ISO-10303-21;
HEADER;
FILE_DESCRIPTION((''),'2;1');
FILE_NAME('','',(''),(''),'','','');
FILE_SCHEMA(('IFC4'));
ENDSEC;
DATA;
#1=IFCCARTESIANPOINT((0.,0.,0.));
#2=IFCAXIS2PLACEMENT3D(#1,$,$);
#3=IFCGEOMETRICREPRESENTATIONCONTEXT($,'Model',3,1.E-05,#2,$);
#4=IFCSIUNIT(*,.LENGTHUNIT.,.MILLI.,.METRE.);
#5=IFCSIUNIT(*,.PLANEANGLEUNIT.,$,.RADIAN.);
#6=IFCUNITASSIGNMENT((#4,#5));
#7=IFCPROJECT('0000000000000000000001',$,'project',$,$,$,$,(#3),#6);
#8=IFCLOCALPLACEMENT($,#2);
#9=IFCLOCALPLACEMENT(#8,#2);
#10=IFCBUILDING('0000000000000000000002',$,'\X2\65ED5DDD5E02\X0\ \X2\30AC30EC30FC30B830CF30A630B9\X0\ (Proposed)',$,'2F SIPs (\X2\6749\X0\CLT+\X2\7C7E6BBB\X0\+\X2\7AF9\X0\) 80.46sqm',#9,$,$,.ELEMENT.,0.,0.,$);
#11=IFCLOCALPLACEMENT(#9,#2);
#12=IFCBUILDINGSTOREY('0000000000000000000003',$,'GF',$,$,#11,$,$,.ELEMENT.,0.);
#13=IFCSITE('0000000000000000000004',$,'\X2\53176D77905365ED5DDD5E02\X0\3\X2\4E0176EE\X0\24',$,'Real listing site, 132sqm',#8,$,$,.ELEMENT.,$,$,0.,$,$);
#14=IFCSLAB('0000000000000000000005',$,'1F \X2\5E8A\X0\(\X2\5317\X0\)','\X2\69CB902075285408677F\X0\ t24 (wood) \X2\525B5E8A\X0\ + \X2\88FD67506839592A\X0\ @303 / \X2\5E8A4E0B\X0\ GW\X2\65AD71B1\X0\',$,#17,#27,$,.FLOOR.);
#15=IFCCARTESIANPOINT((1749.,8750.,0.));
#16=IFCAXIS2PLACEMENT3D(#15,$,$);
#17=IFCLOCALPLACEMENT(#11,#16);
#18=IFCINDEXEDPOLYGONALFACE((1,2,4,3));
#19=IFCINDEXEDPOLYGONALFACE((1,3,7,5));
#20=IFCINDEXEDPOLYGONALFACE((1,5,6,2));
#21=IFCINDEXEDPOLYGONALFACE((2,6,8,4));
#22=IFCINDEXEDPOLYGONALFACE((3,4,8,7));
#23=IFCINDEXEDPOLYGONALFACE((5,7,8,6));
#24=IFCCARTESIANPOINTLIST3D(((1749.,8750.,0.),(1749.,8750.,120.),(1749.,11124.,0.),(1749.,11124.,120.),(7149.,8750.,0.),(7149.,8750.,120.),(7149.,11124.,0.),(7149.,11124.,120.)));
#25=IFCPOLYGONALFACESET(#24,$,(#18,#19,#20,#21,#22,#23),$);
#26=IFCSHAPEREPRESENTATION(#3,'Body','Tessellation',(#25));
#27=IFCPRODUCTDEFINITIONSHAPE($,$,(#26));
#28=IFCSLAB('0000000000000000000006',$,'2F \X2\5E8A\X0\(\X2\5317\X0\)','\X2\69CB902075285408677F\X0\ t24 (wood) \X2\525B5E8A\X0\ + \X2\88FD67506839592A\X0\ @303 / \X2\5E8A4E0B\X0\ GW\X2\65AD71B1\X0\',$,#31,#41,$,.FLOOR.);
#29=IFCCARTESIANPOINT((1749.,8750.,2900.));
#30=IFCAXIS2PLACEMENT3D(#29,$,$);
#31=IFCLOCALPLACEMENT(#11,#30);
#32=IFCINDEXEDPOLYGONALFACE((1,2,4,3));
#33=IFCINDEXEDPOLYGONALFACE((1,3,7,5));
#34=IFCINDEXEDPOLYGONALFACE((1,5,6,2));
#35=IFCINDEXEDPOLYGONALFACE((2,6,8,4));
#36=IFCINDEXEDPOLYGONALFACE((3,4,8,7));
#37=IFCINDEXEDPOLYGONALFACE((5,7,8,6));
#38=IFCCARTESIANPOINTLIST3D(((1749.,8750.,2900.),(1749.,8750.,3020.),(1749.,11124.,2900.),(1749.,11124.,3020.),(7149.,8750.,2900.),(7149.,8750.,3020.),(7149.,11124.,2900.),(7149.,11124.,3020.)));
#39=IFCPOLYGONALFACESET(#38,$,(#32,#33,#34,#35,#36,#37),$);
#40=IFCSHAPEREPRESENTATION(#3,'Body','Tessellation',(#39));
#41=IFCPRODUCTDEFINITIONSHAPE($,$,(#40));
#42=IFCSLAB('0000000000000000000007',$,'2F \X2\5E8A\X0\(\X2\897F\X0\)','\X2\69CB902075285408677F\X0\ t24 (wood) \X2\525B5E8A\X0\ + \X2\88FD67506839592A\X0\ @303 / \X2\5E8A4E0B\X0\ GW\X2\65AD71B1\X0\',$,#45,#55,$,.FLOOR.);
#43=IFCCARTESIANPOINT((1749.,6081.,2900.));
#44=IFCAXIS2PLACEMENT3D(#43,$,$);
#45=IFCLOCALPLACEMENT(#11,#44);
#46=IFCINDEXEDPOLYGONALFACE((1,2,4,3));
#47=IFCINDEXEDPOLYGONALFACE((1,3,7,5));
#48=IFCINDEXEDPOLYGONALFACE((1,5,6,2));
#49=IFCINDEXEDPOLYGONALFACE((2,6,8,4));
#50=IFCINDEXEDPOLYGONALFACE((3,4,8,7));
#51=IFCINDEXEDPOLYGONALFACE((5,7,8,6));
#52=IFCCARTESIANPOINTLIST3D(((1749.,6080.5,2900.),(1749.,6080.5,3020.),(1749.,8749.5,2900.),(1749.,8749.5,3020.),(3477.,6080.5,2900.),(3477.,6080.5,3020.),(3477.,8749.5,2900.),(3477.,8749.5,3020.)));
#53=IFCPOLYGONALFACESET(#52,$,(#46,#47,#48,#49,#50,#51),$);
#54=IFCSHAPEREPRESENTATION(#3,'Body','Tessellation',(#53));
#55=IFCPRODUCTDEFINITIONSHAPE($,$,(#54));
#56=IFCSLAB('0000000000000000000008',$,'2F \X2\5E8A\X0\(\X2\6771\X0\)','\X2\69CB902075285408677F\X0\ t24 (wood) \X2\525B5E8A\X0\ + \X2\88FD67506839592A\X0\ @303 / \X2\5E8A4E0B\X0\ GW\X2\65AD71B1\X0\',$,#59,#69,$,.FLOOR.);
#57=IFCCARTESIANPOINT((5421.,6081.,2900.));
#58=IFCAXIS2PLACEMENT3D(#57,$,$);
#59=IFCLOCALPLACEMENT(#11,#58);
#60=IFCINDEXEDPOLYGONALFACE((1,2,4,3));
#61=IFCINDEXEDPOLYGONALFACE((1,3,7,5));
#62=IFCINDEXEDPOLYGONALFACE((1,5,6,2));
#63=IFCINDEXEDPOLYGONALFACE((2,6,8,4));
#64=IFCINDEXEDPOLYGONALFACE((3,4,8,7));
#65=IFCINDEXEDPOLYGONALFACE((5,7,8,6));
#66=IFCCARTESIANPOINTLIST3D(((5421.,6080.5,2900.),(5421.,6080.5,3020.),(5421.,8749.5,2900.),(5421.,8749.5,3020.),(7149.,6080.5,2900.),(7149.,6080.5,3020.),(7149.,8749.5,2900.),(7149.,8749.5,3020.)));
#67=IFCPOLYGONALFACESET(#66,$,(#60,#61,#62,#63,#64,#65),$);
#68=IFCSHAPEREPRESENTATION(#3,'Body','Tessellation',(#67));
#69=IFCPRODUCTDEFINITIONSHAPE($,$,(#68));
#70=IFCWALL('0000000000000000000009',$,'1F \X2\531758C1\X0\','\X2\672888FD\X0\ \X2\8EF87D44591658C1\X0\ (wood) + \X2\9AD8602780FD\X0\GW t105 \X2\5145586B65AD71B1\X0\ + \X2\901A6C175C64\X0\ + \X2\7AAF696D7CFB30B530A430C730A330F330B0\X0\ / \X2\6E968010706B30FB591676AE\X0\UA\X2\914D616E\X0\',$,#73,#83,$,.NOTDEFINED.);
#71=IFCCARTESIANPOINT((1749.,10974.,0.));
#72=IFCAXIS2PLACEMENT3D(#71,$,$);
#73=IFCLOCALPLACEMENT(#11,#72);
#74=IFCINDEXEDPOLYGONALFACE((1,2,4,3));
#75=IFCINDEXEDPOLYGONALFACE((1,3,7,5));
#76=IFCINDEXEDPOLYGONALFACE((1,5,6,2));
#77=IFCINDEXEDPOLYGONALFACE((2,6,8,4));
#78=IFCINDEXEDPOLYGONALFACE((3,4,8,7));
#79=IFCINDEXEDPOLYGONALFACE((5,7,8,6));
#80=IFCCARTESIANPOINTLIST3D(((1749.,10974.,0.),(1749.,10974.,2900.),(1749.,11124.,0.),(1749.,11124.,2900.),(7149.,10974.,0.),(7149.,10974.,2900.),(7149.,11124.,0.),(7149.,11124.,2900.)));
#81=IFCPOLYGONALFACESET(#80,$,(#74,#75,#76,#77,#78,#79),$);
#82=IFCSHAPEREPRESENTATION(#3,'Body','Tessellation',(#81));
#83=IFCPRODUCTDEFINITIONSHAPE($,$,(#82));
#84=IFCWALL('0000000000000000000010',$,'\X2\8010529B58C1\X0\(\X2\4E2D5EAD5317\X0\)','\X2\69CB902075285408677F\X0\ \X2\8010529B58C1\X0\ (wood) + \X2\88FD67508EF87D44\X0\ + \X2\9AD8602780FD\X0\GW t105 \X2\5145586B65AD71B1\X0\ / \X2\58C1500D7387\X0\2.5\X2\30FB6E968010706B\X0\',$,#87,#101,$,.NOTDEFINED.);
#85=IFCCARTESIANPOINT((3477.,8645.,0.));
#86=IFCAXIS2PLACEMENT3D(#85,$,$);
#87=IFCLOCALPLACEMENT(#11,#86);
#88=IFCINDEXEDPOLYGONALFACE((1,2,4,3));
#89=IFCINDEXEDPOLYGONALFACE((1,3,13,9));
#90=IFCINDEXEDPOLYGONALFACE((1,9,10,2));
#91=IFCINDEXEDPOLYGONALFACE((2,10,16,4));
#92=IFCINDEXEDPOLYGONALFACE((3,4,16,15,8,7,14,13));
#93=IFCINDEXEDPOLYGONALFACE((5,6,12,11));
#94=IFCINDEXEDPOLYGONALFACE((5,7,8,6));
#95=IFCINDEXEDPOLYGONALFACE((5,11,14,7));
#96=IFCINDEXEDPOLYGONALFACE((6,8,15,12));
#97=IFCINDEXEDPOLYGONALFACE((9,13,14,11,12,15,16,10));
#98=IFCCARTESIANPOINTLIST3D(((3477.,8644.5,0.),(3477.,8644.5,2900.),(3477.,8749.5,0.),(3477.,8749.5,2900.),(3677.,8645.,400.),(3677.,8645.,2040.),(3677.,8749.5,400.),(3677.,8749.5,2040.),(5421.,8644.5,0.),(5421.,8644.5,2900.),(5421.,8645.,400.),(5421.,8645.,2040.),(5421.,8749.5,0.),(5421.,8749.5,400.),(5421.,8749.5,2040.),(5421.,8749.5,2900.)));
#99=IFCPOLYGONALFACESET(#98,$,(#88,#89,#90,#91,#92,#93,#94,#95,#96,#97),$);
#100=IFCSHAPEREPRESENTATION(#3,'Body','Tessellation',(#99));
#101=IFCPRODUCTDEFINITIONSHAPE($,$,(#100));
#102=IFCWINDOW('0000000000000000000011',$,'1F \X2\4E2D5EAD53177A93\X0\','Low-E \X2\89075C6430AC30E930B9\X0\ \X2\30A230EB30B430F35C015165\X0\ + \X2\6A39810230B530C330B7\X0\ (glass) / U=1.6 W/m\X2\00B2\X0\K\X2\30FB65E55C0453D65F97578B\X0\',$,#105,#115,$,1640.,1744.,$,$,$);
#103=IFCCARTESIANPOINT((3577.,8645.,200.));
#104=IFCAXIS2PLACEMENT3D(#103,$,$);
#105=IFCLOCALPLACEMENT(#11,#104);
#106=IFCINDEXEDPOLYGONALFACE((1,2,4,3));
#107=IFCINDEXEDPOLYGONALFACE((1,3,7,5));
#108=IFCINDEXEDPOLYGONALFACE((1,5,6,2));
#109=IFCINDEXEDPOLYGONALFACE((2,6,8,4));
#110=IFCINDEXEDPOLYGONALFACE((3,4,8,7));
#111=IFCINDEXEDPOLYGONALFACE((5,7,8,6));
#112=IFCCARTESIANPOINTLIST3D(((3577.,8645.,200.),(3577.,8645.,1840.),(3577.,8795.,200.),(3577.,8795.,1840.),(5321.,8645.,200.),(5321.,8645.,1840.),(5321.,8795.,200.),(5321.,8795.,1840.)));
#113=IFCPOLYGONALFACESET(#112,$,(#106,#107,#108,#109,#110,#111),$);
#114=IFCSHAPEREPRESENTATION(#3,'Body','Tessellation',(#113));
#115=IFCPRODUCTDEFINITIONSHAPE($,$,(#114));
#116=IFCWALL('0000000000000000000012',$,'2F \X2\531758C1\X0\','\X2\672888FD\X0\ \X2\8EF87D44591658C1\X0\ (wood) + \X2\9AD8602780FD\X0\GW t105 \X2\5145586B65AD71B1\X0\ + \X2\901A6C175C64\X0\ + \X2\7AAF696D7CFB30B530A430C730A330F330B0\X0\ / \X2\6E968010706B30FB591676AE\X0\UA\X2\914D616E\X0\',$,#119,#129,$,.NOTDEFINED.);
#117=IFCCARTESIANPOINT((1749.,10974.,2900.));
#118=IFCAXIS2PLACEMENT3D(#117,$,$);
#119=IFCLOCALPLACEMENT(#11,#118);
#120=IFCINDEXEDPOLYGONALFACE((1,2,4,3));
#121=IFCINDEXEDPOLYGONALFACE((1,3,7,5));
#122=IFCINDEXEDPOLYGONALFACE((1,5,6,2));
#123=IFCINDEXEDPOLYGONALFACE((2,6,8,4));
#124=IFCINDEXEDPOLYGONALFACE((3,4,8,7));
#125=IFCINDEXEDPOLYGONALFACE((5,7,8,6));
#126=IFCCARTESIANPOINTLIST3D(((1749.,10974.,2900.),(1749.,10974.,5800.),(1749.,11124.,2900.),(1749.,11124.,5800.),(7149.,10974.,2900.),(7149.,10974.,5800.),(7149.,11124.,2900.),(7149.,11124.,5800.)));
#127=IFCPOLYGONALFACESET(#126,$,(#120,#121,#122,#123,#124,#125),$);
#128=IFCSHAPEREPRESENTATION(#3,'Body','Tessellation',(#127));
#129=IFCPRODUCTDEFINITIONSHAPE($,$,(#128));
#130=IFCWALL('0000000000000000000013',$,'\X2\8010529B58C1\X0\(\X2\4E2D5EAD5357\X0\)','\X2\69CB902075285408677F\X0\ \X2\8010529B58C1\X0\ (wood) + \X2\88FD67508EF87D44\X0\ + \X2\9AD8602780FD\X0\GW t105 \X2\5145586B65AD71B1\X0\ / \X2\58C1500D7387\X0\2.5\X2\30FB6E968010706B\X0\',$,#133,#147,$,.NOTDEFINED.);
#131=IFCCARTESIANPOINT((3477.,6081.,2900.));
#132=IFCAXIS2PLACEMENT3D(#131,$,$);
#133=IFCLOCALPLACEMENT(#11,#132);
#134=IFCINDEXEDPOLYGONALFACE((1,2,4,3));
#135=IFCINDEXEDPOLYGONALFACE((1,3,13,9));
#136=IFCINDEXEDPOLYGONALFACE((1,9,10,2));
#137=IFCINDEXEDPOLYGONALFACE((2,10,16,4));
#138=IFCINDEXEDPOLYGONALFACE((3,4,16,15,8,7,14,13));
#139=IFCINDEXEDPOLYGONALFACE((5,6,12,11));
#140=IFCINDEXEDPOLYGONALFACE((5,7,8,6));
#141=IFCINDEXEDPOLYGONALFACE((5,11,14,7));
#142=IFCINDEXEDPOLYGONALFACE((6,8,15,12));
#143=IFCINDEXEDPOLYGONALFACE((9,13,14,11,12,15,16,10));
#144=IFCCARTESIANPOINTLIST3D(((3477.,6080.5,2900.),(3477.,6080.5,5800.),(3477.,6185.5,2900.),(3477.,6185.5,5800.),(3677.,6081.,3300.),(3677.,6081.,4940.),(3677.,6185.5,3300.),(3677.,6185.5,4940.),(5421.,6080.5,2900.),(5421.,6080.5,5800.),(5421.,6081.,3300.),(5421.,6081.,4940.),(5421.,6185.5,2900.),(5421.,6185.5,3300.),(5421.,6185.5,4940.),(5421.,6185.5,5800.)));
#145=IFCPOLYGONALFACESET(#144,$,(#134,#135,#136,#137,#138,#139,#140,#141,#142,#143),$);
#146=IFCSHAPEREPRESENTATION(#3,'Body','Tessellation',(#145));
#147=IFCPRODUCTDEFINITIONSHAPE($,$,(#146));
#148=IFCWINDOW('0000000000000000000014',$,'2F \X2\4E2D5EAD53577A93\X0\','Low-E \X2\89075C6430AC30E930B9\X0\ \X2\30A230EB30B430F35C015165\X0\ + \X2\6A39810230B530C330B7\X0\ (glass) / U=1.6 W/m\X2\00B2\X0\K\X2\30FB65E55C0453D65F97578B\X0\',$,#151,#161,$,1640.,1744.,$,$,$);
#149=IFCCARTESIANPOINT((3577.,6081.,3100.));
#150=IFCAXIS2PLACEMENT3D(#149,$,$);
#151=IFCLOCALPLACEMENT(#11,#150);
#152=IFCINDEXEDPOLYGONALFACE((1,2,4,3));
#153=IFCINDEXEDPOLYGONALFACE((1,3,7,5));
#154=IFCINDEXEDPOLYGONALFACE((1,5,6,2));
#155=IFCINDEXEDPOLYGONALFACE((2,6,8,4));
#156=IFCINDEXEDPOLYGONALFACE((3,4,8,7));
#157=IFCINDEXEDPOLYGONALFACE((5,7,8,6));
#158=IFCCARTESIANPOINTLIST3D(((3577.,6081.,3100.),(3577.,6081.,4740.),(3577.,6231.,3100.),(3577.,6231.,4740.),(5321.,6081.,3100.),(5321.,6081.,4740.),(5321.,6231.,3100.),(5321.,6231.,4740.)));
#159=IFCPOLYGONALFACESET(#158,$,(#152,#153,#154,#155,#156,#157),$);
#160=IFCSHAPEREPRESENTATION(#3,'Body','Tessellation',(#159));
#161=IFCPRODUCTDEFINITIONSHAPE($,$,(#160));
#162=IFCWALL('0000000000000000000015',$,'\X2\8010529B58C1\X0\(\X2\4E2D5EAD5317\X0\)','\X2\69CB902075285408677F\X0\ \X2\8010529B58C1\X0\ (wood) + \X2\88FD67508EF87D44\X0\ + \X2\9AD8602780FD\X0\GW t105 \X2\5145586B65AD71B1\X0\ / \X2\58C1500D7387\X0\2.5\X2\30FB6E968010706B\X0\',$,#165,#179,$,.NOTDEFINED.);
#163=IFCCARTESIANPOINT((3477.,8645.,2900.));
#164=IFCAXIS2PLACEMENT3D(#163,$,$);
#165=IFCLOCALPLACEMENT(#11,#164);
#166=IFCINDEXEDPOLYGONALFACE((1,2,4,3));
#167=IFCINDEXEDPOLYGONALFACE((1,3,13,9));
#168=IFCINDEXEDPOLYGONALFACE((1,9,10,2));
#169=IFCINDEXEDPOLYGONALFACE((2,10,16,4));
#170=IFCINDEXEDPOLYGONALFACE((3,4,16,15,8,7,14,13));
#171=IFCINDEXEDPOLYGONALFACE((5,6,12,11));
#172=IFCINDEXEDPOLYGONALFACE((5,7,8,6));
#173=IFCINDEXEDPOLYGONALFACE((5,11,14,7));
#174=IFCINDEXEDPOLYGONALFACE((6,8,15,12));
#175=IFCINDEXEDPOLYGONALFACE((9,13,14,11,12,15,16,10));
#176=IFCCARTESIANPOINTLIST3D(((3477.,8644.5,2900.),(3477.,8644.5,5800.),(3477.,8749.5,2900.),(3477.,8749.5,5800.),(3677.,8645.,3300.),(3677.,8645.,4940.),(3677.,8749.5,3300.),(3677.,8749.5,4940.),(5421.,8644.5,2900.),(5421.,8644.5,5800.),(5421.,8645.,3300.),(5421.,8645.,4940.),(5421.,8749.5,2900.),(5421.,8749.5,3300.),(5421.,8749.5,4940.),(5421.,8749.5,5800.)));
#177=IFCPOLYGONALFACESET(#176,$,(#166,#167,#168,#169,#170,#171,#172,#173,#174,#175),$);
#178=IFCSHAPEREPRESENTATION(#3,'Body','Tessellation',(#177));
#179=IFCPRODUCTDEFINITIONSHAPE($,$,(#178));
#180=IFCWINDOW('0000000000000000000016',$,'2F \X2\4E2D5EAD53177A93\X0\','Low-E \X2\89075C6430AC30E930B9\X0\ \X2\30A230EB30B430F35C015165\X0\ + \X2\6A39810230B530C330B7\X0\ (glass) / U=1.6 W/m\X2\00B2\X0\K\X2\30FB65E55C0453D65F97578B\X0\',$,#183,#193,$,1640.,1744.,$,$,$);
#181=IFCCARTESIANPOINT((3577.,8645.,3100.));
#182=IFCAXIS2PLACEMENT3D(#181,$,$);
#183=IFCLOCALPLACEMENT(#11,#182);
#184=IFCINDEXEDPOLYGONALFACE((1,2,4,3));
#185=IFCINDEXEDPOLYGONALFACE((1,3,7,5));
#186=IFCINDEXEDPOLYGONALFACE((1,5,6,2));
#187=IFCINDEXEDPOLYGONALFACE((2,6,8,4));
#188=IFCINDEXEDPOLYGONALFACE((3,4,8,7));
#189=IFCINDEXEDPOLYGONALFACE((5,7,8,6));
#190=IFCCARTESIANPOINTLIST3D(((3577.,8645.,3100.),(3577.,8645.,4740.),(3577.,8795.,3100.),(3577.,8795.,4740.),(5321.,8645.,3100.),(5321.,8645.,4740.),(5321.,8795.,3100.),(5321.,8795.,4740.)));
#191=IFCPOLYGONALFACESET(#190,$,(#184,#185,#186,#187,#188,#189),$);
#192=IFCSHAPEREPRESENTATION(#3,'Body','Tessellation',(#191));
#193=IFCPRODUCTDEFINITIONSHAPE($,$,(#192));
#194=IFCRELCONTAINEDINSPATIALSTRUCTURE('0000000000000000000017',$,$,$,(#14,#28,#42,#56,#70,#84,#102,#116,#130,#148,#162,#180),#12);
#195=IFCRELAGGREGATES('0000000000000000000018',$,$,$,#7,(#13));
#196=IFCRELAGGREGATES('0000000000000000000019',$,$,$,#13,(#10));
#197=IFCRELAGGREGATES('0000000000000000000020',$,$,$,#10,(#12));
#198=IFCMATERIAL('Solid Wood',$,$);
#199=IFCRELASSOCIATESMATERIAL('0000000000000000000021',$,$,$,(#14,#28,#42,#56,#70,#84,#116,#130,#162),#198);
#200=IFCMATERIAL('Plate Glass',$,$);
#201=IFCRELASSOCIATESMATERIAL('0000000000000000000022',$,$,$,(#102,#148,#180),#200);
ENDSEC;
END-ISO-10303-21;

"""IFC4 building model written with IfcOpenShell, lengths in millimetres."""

from ifc_helpers import new_model, si_unit, frame, frame_2d, origin, place, context, project, spatial, rectangle, extrude, material, element, fill, save


model = new_model("IFC4")

# Units and contexts
model_context = context("Model", 3, precision=1e-05, world=origin())
ifc_project = project(units=[si_unit("LENGTHUNIT", "METRE", prefix="MILLI"), si_unit("PLANEANGLEUNIT", "RADIAN")], contexts=[model_context])

# Site, building, storey
site_placement = place(None, origin())
site = spatial("IfcSite", under=ifc_project, at=site_placement, Name="北海道旭川市3丁目24", ObjectType="Real listing site, 132sqm", CompositionType="ELEMENT", RefElevation=0.0)
building_placement = place(site_placement, origin())
building = spatial("IfcBuilding", under=site, at=building_placement, Name="旭川市 ガレージハウス (Proposed)", ObjectType="2F SIPs (杉CLT+籾殻+竹) 80.46sqm", CompositionType="ELEMENT", ElevationOfRefHeight=0.0, ElevationOfTerrain=0.0)
storey_placement = place(building_placement, origin())
storey = spatial("IfcBuildingStorey", under=building, at=storey_placement, Name="GF", CompositionType="ELEMENT", Elevation=0.0)

# Slabs
ifc_material_1 = material(Name="Solid Wood")
slab_1_placement = place(storey_placement, frame((1749.0, 8750.0, 0.0)))
element("IfcSlab", 1, at=slab_1_placement, inside=storey, material=ifc_material_1, Name="1F 床(北)", Description="構造用合板 t24 (wood) 剛床 + 製材根太 @303 / 床下 GW断熱", PredefinedType="FLOOR", context=model_context, shape_type="SweptSolid", body=[
    extrude(rectangle(XDim=5400.0, YDim=2374.0, at=frame_2d((2700.0, 1187.0))), frame((1749.0, 8750.0, 0.0)), (0.0, 0.0, 1.0), 120.0),
])
slab_2_placement = place(storey_placement, frame((1749.0, 8750.0, 2900.0)))
element("IfcSlab", 2, at=slab_2_placement, inside=storey, material=ifc_material_1, Name="2F 床(北)", Description="構造用合板 t24 (wood) 剛床 + 製材根太 @303 / 床下 GW断熱", PredefinedType="FLOOR", context=model_context, shape_type="SweptSolid", body=[
    extrude(rectangle(XDim=5400.0, YDim=2374.0, at=frame_2d((2700.0, 1187.0))), frame((1749.0, 8750.0, 2900.0)), (0.0, 0.0, 1.0), 120.0),
])
slab_3_placement = place(storey_placement, frame((1749.0, 6081.0, 2900.0)))
element("IfcSlab", 3, at=slab_3_placement, inside=storey, material=ifc_material_1, Name="2F 床(西)", Description="構造用合板 t24 (wood) 剛床 + 製材根太 @303 / 床下 GW断熱", PredefinedType="FLOOR", context=model_context, shape_type="SweptSolid", body=[
    extrude(rectangle(XDim=1728.0, YDim=2669.0, at=frame_2d((864.0, 1334.0))), frame((1749.0, 6081.0, 2900.0)), (0.0, 0.0, 1.0), 120.0),
])
slab_4_placement = place(storey_placement, frame((5421.0, 6081.0, 2900.0)))
element("IfcSlab", 4, at=slab_4_placement, inside=storey, material=ifc_material_1, Name="2F 床(東)", Description="構造用合板 t24 (wood) 剛床 + 製材根太 @303 / 床下 GW断熱", PredefinedType="FLOOR", context=model_context, shape_type="SweptSolid", body=[
    extrude(rectangle(XDim=1728.0, YDim=2669.0, at=frame_2d((864.0, 1334.0))), frame((5421.0, 6081.0, 2900.0)), (0.0, 0.0, 1.0), 120.0),
])

# Wall
wall_1_placement = place(storey_placement, frame((1749.0, 10974.0, 0.0)))
element("IfcWall", 5, at=wall_1_placement, inside=storey, material=ifc_material_1, Name="1F 北壁", Description="木製 軸組外壁 (wood) + 高性能GW t105 充填断熱 + 通気層 + 窯業系サイディング / 準耐火・外皮UA配慮", PredefinedType="NOTDEFINED", context=model_context, shape_type="SweptSolid", body=[
    extrude(rectangle(XDim=5400.0, YDim=150.0, at=frame_2d((2700.0, 75.0))), frame((1749.0, 10974.0, 0.0)), (0.0, 0.0, 1.0), 2900.0),
])

# Wall, opening, window
wall_2_placement = place(storey_placement, frame((3477.0, 8645.0, 0.0)))
wall_2 = element("IfcWall", 6, at=wall_2_placement, inside=storey, material=ifc_material_1, Name="耐力壁(中庭北)", Description="構造用合板 耐力壁 (wood) + 製材軸組 + 高性能GW t105 充填断熱 / 壁倍率2.5・準耐火", PredefinedType="NOTDEFINED", context=model_context, shape_type="SweptSolid", body=[
    extrude(rectangle(XDim=1944.0, YDim=105.0, at=frame_2d((972.0, 52.0))), frame((3477.0, 8645.0, 0.0)), (0.0, 0.0, 1.0), 2900.0),
])
opening_1_placement = place(storey_placement, frame((3577.0, 8645.0, 200.0)))
opening_1 = element("IfcOpeningElement", 7, at=opening_1_placement, cuts=wall_2, PredefinedType="NOTDEFINED", context=model_context, shape_type="SweptSolid", body=[
    extrude(rectangle(XDim=1744.0, YDim=150.0, at=frame_2d((872.0, 75.0))), frame((3577.0, 8645.0, 200.0)), (0.0, 0.0, 1.0), 1640.0),
])
ifc_material_2 = material(Name="Plate Glass")
window_1_placement = place(storey_placement, frame((3577.0, 8645.0, 200.0)))
window_1 = element("IfcWindow", 8, at=window_1_placement, inside=storey, material=ifc_material_2, Name="1F 中庭北窓", Description="Low-E 複層ガラス アルゴン封入 + 樹脂サッシ (glass) / U=1.6 W/m²K・日射取得型", OverallHeight=1640.0, OverallWidth=1744.0, context=model_context, shape_type="SweptSolid", body=[
    extrude(rectangle(XDim=1744.0, YDim=150.0, at=frame_2d((872.0, 75.0))), frame((3577.0, 8645.0, 200.0)), (0.0, 0.0, 1.0), 1640.0),
])
fill(opening_1, window_1)

# Wall
wall_3_placement = place(storey_placement, frame((1749.0, 10974.0, 2900.0)))
element("IfcWall", 9, at=wall_3_placement, inside=storey, material=ifc_material_1, Name="2F 北壁", Description="木製 軸組外壁 (wood) + 高性能GW t105 充填断熱 + 通気層 + 窯業系サイディング / 準耐火・外皮UA配慮", PredefinedType="NOTDEFINED", context=model_context, shape_type="SweptSolid", body=[
    extrude(rectangle(XDim=5400.0, YDim=150.0, at=frame_2d((2700.0, 75.0))), frame((1749.0, 10974.0, 2900.0)), (0.0, 0.0, 1.0), 2900.0),
])

# Walls, openings, windows
wall_4_placement = place(storey_placement, frame((3477.0, 6081.0, 2900.0)))
wall_4 = element("IfcWall", 10, at=wall_4_placement, inside=storey, material=ifc_material_1, Name="耐力壁(中庭南)", Description="構造用合板 耐力壁 (wood) + 製材軸組 + 高性能GW t105 充填断熱 / 壁倍率2.5・準耐火", PredefinedType="NOTDEFINED", context=model_context, shape_type="SweptSolid", body=[
    extrude(rectangle(XDim=1944.0, YDim=105.0, at=frame_2d((972.0, 52.0))), frame((3477.0, 6081.0, 2900.0)), (0.0, 0.0, 1.0), 2900.0),
])
opening_2_placement = place(storey_placement, frame((3577.0, 6081.0, 3100.0)))
opening_2 = element("IfcOpeningElement", 11, at=opening_2_placement, cuts=wall_4, PredefinedType="NOTDEFINED", context=model_context, shape_type="SweptSolid", body=[
    extrude(rectangle(XDim=1744.0, YDim=150.0, at=frame_2d((872.0, 75.0))), frame((3577.0, 6081.0, 3100.0)), (0.0, 0.0, 1.0), 1640.0),
])
window_2_placement = place(storey_placement, frame((3577.0, 6081.0, 3100.0)))
window_2 = element("IfcWindow", 12, at=window_2_placement, inside=storey, material=ifc_material_2, Name="2F 中庭南窓", Description="Low-E 複層ガラス アルゴン封入 + 樹脂サッシ (glass) / U=1.6 W/m²K・日射取得型", OverallHeight=1640.0, OverallWidth=1744.0, context=model_context, shape_type="SweptSolid", body=[
    extrude(rectangle(XDim=1744.0, YDim=150.0, at=frame_2d((872.0, 75.0))), frame((3577.0, 6081.0, 3100.0)), (0.0, 0.0, 1.0), 1640.0),
])
fill(opening_2, window_2)
wall_5_placement = place(storey_placement, frame((3477.0, 8645.0, 2900.0)))
wall_5 = element("IfcWall", 13, at=wall_5_placement, inside=storey, material=ifc_material_1, Name="耐力壁(中庭北)", Description="構造用合板 耐力壁 (wood) + 製材軸組 + 高性能GW t105 充填断熱 / 壁倍率2.5・準耐火", PredefinedType="NOTDEFINED", context=model_context, shape_type="SweptSolid", body=[
    extrude(rectangle(XDim=1944.0, YDim=105.0, at=frame_2d((972.0, 52.0))), frame((3477.0, 8645.0, 2900.0)), (0.0, 0.0, 1.0), 2900.0),
])
opening_3_placement = place(storey_placement, frame((3577.0, 8645.0, 3100.0)))
opening_3 = element("IfcOpeningElement", 14, at=opening_3_placement, cuts=wall_5, PredefinedType="NOTDEFINED", context=model_context, shape_type="SweptSolid", body=[
    extrude(rectangle(XDim=1744.0, YDim=150.0, at=frame_2d((872.0, 75.0))), frame((3577.0, 8645.0, 3100.0)), (0.0, 0.0, 1.0), 1640.0),
])
window_3_placement = place(storey_placement, frame((3577.0, 8645.0, 3100.0)))
window_3 = element("IfcWindow", 15, at=window_3_placement, inside=storey, material=ifc_material_2, Name="2F 中庭北窓", Description="Low-E 複層ガラス アルゴン封入 + 樹脂サッシ (glass) / U=1.6 W/m²K・日射取得型", OverallHeight=1640.0, OverallWidth=1744.0, context=model_context, shape_type="SweptSolid", body=[
    extrude(rectangle(XDim=1744.0, YDim=150.0, at=frame_2d((872.0, 75.0))), frame((3577.0, 8645.0, 3100.0)), (0.0, 0.0, 1.0), 1640.0),
])
fill(opening_3, window_3)

save(model, "model.ifc")
